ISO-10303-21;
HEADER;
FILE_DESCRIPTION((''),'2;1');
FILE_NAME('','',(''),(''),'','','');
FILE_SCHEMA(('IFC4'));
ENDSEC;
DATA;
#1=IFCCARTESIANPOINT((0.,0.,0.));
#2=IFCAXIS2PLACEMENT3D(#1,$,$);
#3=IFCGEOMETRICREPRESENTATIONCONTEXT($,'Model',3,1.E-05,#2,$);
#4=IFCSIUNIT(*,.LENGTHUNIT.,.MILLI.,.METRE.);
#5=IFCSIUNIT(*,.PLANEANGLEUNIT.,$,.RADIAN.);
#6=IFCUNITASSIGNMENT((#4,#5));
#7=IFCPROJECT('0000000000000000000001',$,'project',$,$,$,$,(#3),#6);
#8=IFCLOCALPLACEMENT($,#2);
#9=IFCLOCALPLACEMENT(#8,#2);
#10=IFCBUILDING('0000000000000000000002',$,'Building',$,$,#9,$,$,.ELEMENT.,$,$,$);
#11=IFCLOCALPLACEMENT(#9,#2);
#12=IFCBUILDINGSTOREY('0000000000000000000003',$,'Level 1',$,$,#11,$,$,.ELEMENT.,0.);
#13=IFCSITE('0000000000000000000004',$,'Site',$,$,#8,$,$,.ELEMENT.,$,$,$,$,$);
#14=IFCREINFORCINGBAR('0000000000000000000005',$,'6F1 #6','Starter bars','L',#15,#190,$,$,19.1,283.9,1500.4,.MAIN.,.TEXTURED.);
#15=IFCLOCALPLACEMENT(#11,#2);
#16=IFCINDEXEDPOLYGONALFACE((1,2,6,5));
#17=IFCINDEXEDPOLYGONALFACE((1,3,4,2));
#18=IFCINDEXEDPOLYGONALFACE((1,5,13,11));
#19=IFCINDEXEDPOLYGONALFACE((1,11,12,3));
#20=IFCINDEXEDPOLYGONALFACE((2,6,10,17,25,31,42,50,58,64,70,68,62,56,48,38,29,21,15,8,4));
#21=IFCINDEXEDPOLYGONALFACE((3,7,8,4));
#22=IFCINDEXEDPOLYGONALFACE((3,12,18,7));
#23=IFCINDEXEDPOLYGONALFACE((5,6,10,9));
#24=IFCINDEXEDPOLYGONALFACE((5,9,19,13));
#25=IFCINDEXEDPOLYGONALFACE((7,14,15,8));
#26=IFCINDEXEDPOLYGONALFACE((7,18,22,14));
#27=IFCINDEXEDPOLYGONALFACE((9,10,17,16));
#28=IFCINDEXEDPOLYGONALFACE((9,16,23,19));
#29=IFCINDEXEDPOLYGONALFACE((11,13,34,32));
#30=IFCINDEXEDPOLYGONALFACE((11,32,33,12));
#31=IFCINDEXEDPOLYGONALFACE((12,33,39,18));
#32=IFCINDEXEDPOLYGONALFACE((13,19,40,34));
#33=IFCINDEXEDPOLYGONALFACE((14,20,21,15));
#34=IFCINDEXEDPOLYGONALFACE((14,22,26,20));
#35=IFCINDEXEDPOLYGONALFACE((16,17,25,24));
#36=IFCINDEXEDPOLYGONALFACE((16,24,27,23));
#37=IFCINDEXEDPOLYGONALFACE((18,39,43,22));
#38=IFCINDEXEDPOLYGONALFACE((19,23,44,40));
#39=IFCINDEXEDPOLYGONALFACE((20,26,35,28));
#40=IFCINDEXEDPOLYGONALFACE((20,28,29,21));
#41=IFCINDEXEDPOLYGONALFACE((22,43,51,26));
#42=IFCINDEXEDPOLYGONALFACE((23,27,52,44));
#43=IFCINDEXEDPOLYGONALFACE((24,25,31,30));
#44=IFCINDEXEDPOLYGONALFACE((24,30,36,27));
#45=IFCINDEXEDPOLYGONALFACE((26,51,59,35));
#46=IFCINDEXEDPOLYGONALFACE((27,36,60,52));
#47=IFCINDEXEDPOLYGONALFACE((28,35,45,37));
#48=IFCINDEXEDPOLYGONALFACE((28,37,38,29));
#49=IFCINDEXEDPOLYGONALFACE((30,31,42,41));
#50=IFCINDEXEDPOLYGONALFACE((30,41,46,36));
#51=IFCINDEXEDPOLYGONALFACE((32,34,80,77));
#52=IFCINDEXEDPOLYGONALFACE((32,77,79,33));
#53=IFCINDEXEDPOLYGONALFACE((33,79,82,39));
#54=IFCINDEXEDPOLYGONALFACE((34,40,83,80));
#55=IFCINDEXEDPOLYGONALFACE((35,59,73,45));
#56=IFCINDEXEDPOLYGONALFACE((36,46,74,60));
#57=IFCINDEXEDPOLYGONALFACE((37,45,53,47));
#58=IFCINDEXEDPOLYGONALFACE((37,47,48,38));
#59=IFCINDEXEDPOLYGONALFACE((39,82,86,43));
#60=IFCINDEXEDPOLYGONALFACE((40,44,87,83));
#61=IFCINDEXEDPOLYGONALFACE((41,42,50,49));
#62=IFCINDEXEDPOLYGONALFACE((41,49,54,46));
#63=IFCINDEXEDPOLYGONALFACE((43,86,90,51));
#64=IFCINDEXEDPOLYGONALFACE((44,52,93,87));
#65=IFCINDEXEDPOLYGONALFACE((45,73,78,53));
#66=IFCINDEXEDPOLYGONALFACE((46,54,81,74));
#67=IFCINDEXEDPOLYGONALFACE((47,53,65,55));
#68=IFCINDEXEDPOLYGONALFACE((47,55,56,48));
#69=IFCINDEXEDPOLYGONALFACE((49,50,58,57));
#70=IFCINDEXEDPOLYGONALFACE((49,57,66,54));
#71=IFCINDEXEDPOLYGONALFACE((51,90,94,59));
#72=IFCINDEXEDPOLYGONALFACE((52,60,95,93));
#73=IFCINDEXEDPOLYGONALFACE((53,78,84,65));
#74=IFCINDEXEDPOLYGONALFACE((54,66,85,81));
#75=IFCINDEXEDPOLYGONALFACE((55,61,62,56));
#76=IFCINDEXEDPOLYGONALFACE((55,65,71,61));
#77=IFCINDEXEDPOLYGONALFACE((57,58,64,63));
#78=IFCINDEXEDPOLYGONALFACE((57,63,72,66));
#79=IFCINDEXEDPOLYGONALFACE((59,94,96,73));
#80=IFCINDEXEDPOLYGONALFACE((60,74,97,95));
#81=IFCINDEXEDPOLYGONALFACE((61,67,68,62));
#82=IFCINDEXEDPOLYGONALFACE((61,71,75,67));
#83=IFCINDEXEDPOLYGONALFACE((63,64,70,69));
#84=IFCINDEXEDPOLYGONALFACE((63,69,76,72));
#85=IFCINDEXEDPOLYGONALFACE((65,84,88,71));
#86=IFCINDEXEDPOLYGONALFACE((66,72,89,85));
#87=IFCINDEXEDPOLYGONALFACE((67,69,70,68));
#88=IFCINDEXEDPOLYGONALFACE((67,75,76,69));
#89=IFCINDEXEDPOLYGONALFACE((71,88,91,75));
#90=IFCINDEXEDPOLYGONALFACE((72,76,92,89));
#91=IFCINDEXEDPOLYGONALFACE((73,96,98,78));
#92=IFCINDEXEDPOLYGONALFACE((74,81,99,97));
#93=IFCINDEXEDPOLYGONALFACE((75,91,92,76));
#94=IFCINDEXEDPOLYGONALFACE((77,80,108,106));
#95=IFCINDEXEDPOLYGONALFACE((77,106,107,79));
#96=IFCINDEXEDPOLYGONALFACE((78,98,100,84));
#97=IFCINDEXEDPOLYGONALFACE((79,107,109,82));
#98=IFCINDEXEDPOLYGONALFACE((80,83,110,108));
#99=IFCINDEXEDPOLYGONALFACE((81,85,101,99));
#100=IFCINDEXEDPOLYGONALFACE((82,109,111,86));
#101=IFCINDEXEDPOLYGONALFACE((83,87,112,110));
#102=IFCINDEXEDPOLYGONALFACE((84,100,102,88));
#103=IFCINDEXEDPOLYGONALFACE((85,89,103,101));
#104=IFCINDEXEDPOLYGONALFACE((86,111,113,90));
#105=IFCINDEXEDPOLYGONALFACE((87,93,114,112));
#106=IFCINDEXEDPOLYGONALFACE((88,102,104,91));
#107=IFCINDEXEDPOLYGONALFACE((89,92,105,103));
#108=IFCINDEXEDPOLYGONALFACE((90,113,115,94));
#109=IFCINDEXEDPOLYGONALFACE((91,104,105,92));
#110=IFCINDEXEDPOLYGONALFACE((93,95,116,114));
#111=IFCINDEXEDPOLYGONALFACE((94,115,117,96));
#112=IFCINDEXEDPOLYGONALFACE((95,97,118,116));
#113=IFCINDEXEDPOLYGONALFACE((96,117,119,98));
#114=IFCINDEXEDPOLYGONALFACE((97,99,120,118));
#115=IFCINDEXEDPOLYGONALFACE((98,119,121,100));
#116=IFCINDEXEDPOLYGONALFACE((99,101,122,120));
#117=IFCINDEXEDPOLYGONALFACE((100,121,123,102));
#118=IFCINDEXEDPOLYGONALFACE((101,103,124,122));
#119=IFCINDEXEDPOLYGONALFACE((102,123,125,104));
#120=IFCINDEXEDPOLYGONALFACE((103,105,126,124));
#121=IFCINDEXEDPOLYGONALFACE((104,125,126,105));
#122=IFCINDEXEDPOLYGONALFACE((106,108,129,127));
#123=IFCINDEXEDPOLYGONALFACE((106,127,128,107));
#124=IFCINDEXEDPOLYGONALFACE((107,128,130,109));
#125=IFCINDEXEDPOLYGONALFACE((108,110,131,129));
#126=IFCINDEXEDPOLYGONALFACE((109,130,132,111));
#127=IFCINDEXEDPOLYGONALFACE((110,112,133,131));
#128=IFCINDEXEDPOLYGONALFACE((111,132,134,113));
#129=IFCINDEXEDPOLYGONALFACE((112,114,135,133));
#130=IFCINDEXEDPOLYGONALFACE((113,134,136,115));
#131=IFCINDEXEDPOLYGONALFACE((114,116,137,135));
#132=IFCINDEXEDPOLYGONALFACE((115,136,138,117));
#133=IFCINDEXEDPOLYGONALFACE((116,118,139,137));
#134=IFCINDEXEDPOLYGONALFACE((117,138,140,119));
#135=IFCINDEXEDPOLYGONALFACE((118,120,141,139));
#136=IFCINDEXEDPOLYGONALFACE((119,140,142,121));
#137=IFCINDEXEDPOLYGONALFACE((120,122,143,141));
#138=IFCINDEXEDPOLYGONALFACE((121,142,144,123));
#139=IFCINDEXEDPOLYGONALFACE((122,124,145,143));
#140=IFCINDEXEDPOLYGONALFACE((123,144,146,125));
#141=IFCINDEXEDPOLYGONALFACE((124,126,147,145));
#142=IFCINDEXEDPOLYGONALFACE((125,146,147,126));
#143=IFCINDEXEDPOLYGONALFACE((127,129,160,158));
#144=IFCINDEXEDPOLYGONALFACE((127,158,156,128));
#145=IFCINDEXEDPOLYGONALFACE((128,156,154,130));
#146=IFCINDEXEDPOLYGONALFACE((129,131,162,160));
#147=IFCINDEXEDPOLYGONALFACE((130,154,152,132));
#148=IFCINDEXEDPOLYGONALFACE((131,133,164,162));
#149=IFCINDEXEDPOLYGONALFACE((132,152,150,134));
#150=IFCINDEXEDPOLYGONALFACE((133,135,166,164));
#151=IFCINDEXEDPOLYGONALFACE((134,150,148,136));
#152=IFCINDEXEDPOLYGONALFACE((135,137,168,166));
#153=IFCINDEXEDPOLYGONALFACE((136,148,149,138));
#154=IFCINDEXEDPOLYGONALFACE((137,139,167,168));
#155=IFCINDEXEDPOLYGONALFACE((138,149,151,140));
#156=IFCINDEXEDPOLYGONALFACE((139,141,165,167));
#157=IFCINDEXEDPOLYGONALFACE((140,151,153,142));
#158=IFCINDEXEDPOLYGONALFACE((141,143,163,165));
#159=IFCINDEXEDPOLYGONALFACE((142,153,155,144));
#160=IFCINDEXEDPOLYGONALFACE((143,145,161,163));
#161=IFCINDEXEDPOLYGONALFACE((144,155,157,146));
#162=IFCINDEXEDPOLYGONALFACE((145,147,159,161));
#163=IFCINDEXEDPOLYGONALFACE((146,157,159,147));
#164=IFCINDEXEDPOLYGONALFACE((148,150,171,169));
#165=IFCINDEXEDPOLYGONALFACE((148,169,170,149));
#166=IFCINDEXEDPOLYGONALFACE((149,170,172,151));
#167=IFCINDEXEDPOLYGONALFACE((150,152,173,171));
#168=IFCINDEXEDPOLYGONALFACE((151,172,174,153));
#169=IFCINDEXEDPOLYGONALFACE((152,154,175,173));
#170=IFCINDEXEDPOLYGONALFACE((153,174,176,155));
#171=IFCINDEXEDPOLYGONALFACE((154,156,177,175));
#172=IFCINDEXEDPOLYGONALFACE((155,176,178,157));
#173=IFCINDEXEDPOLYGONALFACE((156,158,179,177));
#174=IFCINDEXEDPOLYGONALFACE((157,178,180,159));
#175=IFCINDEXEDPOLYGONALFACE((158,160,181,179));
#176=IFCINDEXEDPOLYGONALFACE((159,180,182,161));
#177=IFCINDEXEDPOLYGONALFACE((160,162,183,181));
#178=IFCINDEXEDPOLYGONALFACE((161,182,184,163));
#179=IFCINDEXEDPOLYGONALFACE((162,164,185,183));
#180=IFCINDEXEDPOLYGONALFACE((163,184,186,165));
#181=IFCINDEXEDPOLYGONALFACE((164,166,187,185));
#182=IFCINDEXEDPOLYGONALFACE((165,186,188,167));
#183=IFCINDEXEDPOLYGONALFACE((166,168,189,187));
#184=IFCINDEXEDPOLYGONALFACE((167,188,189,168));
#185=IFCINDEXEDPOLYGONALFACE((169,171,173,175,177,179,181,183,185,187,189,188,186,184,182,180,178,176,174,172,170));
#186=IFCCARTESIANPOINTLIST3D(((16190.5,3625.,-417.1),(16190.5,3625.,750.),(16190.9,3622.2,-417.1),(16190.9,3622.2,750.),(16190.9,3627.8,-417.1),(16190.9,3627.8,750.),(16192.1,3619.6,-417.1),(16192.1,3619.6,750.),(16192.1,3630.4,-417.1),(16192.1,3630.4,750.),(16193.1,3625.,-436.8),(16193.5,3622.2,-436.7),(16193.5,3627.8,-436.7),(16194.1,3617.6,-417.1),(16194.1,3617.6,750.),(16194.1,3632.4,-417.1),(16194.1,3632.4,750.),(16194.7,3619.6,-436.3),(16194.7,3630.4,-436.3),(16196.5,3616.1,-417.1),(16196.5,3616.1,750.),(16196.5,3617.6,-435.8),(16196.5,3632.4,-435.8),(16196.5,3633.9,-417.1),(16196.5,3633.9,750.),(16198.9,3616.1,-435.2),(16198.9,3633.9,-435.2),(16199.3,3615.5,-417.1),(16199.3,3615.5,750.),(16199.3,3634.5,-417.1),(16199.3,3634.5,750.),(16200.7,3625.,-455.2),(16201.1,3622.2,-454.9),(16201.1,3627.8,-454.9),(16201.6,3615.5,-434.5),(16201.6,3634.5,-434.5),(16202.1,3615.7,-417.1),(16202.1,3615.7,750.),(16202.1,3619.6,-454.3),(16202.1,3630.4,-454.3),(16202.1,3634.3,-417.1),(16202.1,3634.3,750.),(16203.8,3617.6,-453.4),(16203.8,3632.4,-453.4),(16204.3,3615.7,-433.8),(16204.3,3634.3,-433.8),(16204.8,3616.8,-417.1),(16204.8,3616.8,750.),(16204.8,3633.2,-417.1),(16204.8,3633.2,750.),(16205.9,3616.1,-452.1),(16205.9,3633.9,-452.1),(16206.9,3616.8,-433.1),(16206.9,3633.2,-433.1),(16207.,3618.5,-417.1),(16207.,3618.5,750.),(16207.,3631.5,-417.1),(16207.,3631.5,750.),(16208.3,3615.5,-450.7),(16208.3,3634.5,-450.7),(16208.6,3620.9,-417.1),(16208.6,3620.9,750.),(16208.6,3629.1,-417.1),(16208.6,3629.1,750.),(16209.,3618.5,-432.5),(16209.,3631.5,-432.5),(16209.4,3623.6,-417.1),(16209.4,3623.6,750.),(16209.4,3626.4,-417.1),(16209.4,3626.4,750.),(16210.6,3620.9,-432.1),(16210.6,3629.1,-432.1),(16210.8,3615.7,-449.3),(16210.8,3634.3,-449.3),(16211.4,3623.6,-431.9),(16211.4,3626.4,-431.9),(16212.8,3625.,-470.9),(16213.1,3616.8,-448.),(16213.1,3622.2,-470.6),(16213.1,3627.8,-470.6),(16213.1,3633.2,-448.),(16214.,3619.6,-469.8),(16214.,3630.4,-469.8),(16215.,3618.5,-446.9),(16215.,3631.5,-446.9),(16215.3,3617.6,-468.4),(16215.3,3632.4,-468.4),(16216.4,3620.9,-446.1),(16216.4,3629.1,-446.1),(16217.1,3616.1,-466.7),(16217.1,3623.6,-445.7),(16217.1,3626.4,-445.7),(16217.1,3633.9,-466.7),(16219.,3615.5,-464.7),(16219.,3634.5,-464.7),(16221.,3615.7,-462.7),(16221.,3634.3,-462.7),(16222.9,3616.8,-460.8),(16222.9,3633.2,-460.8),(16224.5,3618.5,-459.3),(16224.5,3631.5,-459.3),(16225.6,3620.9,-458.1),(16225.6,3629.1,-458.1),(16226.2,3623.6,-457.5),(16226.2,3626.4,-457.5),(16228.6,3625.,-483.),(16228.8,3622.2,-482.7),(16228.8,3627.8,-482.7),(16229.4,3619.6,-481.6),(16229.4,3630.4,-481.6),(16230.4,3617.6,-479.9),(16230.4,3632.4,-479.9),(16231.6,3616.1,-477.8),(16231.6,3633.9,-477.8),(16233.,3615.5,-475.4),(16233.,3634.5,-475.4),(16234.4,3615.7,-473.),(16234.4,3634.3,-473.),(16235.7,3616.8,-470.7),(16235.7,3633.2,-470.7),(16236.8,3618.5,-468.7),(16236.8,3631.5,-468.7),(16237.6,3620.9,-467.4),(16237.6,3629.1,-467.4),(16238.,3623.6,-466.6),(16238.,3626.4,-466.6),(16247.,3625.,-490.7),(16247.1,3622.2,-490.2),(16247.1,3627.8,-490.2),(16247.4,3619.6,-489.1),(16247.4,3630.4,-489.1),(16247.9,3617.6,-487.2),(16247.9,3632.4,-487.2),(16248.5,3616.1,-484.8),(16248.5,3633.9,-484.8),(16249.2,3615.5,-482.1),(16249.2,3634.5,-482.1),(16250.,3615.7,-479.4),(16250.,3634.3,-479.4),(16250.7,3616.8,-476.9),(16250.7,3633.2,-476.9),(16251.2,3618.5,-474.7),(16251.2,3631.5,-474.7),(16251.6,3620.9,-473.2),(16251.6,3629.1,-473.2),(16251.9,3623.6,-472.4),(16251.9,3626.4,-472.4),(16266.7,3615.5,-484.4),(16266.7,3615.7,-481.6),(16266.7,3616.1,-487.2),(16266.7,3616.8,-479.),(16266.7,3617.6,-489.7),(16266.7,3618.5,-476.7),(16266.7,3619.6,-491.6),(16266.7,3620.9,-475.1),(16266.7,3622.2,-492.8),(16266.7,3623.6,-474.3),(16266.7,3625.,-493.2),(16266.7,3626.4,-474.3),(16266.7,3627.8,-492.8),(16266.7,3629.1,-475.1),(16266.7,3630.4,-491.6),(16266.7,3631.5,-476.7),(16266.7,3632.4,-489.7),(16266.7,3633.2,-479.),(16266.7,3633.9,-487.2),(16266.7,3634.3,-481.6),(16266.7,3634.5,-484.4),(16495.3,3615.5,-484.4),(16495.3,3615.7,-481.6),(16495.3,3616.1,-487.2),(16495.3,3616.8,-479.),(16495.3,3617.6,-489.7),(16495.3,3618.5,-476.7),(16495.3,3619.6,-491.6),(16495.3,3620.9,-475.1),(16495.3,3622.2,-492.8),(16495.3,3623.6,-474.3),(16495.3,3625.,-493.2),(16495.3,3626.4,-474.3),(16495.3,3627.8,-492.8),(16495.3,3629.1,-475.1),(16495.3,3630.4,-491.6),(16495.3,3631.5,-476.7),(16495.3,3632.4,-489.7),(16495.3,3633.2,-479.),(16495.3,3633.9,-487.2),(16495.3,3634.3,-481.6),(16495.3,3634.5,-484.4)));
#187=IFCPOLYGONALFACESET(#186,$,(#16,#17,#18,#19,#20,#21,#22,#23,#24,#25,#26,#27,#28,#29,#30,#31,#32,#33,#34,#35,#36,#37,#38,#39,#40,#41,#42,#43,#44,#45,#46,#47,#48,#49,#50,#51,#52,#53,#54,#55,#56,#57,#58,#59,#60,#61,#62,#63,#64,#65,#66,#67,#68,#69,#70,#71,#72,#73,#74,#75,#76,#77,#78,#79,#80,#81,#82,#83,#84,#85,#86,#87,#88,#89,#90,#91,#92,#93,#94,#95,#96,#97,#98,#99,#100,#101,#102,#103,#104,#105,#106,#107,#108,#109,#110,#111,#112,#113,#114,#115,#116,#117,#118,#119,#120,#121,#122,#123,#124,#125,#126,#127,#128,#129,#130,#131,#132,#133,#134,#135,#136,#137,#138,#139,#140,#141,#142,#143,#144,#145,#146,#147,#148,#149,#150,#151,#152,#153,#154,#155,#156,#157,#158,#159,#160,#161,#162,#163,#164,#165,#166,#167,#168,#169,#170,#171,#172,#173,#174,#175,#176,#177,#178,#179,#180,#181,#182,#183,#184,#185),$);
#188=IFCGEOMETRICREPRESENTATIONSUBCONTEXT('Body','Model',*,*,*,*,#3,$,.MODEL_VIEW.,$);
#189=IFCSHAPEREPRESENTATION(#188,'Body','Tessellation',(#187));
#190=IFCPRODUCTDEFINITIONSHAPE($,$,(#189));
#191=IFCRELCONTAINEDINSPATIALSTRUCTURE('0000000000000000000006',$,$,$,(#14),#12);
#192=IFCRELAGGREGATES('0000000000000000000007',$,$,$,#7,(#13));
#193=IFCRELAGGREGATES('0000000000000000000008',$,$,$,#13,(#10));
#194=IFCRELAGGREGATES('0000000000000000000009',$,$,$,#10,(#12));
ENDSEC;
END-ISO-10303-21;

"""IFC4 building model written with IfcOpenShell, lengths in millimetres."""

from ifc_helpers import new_model, entity, si_unit, origin, place, context, subcontext, project, spatial, element, save


model = new_model("IFC4")

# Units and contexts
model_context = context("Model", 3, precision=1e-05, world=origin())
body_context = subcontext(model_context, "Body", "Model", "MODEL_VIEW")
ifc_project = project(units=[si_unit("LENGTHUNIT", "METRE", prefix="MILLI"), si_unit("PLANEANGLEUNIT", "RADIAN")], contexts=[model_context])

# Site, building, storey
site_placement = place(None, origin())
site = spatial("IfcSite", under=ifc_project, at=site_placement, Name="Site", CompositionType="ELEMENT")
building_placement = place(site_placement, origin())
building = spatial("IfcBuilding", under=site, at=building_placement, Name="Building", CompositionType="ELEMENT")
storey_placement = place(building_placement, origin())
storey = spatial("IfcBuildingStorey", under=building, at=storey_placement, Name="Level 1", CompositionType="ELEMENT", Elevation=0.0)

# Reinforcing bar
reinforcing_bar_1_placement = place(storey_placement, origin())
element("IfcReinforcingBar", 1, at=reinforcing_bar_1_placement, inside=storey, Name="6F1 #6", Description="Starter bars", ObjectType="L", BarLength=1500.4, BarSurface="TEXTURED", CrossSectionArea=283.9, NominalDiameter=19.1, PredefinedType="MAIN", context=body_context, shape_type="AdvancedSweptSolid", body=[
    entity("IfcSweptDiskSolid", entity("IfcIndexedPolyCurve", entity("IfcCartesianPointList3D", [[16200.0, 3625.0, 750.0], [16200.0, 3625.0, -417.1], [16219.5, 3625.0, -464.2], [16266.7, 3625.0, -483.7], [16495.3, 3625.0, -483.7]]), [entity("IfcLineIndex", [1, 2]), entity("IfcArcIndex", [2, 3, 4]), entity("IfcLineIndex", [4, 5])], False), 9.5),
])

save(model, "model.ifc")
